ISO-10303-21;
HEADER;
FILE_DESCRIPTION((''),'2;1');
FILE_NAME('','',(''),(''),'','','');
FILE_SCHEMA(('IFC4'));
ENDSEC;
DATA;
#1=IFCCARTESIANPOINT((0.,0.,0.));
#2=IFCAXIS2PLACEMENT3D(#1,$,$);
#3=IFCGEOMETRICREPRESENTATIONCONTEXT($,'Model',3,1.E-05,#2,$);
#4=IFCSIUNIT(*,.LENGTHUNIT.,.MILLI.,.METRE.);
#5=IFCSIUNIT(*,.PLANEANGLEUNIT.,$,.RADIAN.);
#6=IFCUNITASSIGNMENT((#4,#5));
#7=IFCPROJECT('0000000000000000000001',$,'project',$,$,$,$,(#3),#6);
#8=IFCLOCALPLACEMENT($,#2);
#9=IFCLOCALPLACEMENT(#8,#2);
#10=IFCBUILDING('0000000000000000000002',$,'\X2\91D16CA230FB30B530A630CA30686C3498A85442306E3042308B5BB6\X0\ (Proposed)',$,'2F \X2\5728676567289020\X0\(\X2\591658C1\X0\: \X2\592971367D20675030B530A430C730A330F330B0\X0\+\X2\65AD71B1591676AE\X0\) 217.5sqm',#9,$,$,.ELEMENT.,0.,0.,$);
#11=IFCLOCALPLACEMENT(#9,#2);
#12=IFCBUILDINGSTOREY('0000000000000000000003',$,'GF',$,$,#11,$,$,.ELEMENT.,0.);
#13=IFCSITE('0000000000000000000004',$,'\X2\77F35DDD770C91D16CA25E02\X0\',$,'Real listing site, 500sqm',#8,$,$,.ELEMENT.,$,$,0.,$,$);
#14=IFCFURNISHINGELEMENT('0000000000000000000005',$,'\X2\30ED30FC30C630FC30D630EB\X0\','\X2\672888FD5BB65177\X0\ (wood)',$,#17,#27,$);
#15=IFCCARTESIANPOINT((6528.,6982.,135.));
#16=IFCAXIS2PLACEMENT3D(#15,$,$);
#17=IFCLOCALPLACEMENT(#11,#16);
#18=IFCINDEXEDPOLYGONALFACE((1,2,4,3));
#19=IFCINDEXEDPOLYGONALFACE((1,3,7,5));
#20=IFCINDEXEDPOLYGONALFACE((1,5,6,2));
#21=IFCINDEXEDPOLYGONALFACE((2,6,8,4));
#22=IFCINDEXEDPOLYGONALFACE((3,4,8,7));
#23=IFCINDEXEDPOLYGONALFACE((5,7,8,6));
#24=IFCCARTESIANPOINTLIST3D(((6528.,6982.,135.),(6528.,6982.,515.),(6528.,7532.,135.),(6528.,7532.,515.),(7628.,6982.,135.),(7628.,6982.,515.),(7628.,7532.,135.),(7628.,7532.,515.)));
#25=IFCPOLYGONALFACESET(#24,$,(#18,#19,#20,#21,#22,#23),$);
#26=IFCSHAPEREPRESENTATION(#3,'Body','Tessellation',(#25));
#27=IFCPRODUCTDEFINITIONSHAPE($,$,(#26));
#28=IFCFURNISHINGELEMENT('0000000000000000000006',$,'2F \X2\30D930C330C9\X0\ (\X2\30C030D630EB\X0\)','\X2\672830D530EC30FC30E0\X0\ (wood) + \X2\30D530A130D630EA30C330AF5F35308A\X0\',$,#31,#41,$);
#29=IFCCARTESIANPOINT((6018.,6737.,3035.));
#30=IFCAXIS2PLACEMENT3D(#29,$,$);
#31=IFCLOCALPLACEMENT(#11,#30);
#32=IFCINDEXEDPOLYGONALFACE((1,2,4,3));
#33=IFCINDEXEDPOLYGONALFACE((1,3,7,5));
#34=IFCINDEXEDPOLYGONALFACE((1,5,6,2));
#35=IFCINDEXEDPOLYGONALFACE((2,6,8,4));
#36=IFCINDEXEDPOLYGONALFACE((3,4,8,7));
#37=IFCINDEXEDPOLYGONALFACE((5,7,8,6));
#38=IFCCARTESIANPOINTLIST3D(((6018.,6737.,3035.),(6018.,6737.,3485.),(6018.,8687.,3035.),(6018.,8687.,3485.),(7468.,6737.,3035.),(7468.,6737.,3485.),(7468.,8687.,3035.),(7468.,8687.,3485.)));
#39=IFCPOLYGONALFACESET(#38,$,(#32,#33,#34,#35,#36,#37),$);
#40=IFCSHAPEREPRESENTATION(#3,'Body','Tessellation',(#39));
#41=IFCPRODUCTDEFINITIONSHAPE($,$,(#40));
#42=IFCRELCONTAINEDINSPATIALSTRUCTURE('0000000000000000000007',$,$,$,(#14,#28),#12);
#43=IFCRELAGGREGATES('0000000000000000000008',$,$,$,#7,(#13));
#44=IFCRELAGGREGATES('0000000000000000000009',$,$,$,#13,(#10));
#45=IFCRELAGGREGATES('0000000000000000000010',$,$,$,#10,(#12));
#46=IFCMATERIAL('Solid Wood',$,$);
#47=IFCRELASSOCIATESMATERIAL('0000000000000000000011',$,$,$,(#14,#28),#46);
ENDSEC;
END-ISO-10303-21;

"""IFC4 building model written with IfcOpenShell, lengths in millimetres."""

from ifc_helpers import new_model, si_unit, frame, frame_2d, origin, place, context, project, spatial, rectangle, extrude, material, element, save


model = new_model("IFC4")

# Units and contexts
model_context = context("Model", 3, precision=1e-05, world=origin())
ifc_project = project(units=[si_unit("LENGTHUNIT", "METRE", prefix="MILLI"), si_unit("PLANEANGLEUNIT", "RADIAN")], contexts=[model_context])

# Site, building, storey
site_placement = place(None, origin())
site = spatial("IfcSite", under=ifc_project, at=site_placement, Name="石川県金沢市", ObjectType="Real listing site, 500sqm", CompositionType="ELEMENT", RefElevation=0.0)
building_placement = place(site_placement, origin())
building = spatial("IfcBuilding", under=site, at=building_placement, Name="金沢・サウナと水風呂のある家 (Proposed)", ObjectType="2F 在来木造(外壁: 天然素材サイディング+断熱外皮) 217.5sqm", CompositionType="ELEMENT", ElevationOfRefHeight=0.0, ElevationOfTerrain=0.0)
storey_placement = place(building_placement, origin())
storey = spatial("IfcBuildingStorey", under=building, at=storey_placement, Name="GF", CompositionType="ELEMENT", Elevation=0.0)

# Shared definitions
ifc_material_1 = material(Name="Solid Wood")

# Furnishing elements
furnishing_1_placement = place(storey_placement, frame((6528.0, 6982.0, 135.0)))
element("IfcFurnishingElement", 1, at=furnishing_1_placement, inside=storey, material=ifc_material_1, Name="ローテーブル", Description="木製家具 (wood)", context=model_context, shape_type="SweptSolid", body=[
    extrude(rectangle(XDim=1100.0, YDim=550.0, at=frame_2d((550.0, 275.0))), frame((6528.0, 6982.0, 135.0)), (0.0, 0.0, 1.0), 380.0),
])
furnishing_2_placement = place(storey_placement, frame((6018.0, 6737.0, 3035.0)))
element("IfcFurnishingElement", 2, at=furnishing_2_placement, inside=storey, material=ifc_material_1, Name="2F ベッド (ダブル)", Description="木フレーム (wood) + ファブリック張り", context=model_context, shape_type="SweptSolid", body=[
    extrude(rectangle(XDim=1450.0, YDim=1950.0, at=frame_2d((725.0, 975.0))), frame((6018.0, 6737.0, 3035.0)), (0.0, 0.0, 1.0), 450.0),
])

save(model, "model.ifc")
